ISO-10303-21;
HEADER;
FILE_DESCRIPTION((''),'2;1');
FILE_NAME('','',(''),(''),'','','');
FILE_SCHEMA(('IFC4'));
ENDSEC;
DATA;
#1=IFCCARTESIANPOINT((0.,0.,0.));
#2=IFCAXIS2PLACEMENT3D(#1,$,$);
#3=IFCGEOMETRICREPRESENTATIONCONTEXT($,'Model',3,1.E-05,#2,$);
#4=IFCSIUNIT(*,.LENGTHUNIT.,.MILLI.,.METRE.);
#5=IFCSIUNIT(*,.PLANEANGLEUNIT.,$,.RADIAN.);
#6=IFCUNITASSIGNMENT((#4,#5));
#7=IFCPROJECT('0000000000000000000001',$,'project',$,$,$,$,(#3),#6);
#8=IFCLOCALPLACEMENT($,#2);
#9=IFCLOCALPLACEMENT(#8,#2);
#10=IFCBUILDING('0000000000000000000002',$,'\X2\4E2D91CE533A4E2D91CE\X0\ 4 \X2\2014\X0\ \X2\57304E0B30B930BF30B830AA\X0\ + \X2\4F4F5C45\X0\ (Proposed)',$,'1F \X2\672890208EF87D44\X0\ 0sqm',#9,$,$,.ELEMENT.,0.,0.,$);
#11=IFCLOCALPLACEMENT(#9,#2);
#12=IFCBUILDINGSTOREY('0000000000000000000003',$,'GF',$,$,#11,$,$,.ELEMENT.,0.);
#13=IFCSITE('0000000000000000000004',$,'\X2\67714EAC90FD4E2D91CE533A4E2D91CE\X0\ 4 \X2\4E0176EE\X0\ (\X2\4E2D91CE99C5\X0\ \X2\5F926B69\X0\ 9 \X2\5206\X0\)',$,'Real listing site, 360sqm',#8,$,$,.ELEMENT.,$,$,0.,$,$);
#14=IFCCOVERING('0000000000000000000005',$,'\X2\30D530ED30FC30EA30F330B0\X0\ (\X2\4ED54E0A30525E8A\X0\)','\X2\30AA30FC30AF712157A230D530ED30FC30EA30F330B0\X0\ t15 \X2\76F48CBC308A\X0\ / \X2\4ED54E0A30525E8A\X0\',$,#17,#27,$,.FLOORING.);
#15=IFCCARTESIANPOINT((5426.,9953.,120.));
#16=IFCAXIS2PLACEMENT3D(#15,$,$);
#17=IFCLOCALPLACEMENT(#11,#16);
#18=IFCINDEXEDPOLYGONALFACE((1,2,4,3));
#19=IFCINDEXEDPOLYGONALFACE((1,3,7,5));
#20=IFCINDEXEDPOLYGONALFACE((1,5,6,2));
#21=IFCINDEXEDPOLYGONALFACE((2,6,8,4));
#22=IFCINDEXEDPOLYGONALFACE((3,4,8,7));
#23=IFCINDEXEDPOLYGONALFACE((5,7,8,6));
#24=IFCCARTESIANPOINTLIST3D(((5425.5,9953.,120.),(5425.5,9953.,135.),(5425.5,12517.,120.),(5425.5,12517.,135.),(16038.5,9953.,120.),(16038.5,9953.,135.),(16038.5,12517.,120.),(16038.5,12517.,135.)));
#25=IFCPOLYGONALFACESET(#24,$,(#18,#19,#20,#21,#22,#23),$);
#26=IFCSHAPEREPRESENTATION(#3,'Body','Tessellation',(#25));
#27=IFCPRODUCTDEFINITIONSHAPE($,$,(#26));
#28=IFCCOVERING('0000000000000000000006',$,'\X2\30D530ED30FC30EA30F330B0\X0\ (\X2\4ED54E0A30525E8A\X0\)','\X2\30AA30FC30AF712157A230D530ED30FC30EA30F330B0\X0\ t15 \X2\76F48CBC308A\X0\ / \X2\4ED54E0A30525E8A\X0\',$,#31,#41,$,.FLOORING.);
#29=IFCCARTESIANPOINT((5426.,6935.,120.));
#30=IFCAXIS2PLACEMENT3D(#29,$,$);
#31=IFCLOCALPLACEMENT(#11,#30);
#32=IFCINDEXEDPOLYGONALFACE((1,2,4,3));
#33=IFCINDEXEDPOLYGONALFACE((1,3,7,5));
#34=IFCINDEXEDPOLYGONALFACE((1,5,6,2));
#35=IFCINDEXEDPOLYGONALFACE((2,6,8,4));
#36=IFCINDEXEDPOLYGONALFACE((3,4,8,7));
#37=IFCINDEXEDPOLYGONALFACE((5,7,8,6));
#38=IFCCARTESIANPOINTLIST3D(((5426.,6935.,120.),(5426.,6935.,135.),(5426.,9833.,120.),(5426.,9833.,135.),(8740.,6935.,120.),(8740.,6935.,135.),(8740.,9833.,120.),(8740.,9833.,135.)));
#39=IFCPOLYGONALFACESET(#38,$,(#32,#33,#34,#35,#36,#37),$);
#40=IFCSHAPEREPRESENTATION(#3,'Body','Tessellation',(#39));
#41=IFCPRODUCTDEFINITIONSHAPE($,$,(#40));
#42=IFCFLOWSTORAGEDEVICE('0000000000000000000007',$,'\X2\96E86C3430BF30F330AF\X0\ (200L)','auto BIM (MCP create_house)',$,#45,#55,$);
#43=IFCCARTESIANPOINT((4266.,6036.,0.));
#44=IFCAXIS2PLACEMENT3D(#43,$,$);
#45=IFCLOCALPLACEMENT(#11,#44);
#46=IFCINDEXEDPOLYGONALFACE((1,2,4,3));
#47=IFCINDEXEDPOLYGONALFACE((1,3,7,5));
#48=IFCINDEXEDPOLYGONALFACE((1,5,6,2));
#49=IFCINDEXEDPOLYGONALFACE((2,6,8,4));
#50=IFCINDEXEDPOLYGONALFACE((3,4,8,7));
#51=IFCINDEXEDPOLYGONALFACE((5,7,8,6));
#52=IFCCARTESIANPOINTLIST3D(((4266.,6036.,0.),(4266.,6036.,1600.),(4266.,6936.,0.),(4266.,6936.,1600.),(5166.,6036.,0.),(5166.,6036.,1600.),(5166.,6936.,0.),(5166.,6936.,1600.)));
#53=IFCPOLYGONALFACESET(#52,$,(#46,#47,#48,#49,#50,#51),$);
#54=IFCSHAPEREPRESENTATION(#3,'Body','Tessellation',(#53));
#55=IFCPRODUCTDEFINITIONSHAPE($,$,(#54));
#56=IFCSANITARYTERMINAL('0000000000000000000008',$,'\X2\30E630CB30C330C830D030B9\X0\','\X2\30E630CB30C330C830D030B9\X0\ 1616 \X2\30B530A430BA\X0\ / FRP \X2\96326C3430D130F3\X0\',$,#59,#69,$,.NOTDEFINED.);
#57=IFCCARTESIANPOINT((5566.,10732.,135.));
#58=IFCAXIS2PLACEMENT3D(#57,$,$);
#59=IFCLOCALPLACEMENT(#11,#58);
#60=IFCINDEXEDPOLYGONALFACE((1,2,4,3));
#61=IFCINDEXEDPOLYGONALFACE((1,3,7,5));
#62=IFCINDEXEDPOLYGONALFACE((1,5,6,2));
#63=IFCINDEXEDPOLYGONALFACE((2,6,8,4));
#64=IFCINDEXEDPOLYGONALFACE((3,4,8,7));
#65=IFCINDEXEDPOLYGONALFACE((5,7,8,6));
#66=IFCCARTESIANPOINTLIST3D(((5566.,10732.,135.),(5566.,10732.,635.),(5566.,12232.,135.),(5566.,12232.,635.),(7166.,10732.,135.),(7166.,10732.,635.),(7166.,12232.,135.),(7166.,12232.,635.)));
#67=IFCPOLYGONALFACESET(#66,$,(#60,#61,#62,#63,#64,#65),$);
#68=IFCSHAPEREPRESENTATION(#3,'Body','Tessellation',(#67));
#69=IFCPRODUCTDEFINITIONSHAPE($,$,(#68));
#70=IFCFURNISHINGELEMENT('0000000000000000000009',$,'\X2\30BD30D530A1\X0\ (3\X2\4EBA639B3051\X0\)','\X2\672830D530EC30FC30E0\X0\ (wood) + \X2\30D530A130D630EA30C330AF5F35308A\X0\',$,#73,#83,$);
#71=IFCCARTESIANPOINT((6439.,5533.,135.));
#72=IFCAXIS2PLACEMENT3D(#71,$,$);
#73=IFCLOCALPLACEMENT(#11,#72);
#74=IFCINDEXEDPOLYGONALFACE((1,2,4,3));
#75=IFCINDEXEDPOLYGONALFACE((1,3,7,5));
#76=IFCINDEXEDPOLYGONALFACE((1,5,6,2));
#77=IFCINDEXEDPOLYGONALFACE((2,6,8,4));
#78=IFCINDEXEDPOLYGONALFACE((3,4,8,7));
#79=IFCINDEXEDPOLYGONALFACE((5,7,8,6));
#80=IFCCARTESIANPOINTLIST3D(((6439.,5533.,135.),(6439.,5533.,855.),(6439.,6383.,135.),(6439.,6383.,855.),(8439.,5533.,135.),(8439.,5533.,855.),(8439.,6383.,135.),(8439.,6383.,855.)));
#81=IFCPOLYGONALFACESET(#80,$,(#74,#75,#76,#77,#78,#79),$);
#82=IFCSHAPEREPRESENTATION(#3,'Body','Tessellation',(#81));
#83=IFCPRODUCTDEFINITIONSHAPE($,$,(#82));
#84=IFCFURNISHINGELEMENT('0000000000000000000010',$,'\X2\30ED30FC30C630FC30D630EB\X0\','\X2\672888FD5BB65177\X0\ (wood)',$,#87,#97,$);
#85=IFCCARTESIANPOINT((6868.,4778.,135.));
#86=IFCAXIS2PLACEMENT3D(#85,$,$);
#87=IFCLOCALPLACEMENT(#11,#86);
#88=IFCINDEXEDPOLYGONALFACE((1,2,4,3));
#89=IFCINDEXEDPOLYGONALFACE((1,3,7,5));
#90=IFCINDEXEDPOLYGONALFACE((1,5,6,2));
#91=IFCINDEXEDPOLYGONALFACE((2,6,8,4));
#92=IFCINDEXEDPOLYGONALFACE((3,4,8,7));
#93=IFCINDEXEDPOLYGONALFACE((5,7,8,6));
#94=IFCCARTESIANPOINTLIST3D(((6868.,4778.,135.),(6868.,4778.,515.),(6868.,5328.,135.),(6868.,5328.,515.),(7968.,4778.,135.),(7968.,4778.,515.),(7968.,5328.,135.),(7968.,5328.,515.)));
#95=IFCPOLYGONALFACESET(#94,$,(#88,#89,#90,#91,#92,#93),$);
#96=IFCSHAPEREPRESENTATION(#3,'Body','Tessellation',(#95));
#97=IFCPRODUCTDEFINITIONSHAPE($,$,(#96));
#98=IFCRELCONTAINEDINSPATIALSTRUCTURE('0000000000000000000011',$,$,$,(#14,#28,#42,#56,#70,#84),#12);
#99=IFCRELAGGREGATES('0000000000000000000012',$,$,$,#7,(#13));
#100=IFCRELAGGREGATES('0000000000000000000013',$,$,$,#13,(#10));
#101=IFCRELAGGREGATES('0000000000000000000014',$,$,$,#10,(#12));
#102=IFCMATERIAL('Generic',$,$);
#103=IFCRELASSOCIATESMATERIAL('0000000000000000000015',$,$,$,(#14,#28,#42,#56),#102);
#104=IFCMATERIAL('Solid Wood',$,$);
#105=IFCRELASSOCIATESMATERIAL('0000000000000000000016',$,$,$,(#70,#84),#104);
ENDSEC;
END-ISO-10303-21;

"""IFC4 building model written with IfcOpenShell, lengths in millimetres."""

from ifc_helpers import new_model, si_unit, frame, frame_2d, origin, place, context, project, spatial, rectangle, extrude, material, element, save


model = new_model("IFC4")

# Units and contexts
model_context = context("Model", 3, precision=1e-05, world=origin())
ifc_project = project(units=[si_unit("LENGTHUNIT", "METRE", prefix="MILLI"), si_unit("PLANEANGLEUNIT", "RADIAN")], contexts=[model_context])

# Site, building, storey
site_placement = place(None, origin())
site = spatial("IfcSite", under=ifc_project, at=site_placement, Name="東京都中野区中野 4 丁目 (中野駅 徒歩 9 分)", ObjectType="Real listing site, 360sqm", CompositionType="ELEMENT", RefElevation=0.0)
building_placement = place(site_placement, origin())
building = spatial("IfcBuilding", under=site, at=building_placement, Name="中野区中野 4 — 地下スタジオ + 住居 (Proposed)", ObjectType="1F 木造軸組 0sqm", CompositionType="ELEMENT", ElevationOfRefHeight=0.0, ElevationOfTerrain=0.0)
storey_placement = place(building_placement, origin())
storey = spatial("IfcBuildingStorey", under=building, at=storey_placement, Name="GF", CompositionType="ELEMENT", Elevation=0.0)

# Shared definitions
ifc_material_1 = material(Name="Solid Wood")

# Coverings
ifc_material_2 = material(Name="Generic")
covering_1_placement = place(storey_placement, frame((5426.0, 9953.0, 120.0)))
element("IfcCovering", 1, at=covering_1_placement, inside=storey, material=ifc_material_2, Name="フローリング (仕上げ床)", Description="オーク無垢フローリング t15 直貼り / 仕上げ床", PredefinedType="FLOORING", context=model_context, shape_type="SweptSolid", body=[
    extrude(rectangle(XDim=10613.0, YDim=2564.0, at=frame_2d((5306.0, 1282.0))), frame((5426.0, 9953.0, 120.0)), (0.0, 0.0, 1.0), 15.0),
])
covering_2_placement = place(storey_placement, frame((5426.0, 6935.0, 120.0)))
element("IfcCovering", 2, at=covering_2_placement, inside=storey, material=ifc_material_2, Name="フローリング (仕上げ床)", Description="オーク無垢フローリング t15 直貼り / 仕上げ床", PredefinedType="FLOORING", context=model_context, shape_type="SweptSolid", body=[
    extrude(rectangle(XDim=3314.0, YDim=2898.0, at=frame_2d((1657.0, 1449.0))), frame((5426.0, 6935.0, 120.0)), (0.0, 0.0, 1.0), 15.0),
])

# Flow storage device
flow_storage_device_placement = place(storey_placement, frame((4266.0, 6036.0, 0.0)))
element("IfcFlowStorageDevice", 3, at=flow_storage_device_placement, inside=storey, material=ifc_material_2, Name="雨水タンク (200L)", Description="auto BIM (MCP create_house)", context=model_context, shape_type="SweptSolid", body=[
    extrude(rectangle(XDim=900.0, YDim=900.0, at=frame_2d((450.0, 450.0))), frame((4266.0, 6036.0, 0.0)), (0.0, 0.0, 1.0), 1600.0),
])

# Sanitary terminal
sanitary_terminal_placement = place(storey_placement, frame((5566.0, 10732.0, 135.0)))
element("IfcSanitaryTerminal", 4, at=sanitary_terminal_placement, inside=storey, material=ifc_material_2, Name="ユニットバス", Description="ユニットバス 1616 サイズ / FRP 防水パン", PredefinedType="NOTDEFINED", context=model_context, shape_type="SweptSolid", body=[
    extrude(rectangle(XDim=1600.0, YDim=1500.0, at=frame_2d((800.0, 750.0))), frame((5566.0, 10732.0, 135.0)), (0.0, 0.0, 1.0), 500.0),
])

# Furnishing elements
furnishing_1_placement = place(storey_placement, frame((6439.0, 5533.0, 135.0)))
element("IfcFurnishingElement", 5, at=furnishing_1_placement, inside=storey, material=ifc_material_1, Name="ソファ (3人掛け)", Description="木フレーム (wood) + ファブリック張り", context=model_context, shape_type="SweptSolid", body=[
    extrude(rectangle(XDim=2000.0, YDim=850.0, at=frame_2d((1000.0, 425.0))), frame((6439.0, 5533.0, 135.0)), (0.0, 0.0, 1.0), 720.0),
])
furnishing_2_placement = place(storey_placement, frame((6868.0, 4778.0, 135.0)))
element("IfcFurnishingElement", 6, at=furnishing_2_placement, inside=storey, material=ifc_material_1, Name="ローテーブル", Description="木製家具 (wood)", context=model_context, shape_type="SweptSolid", body=[
    extrude(rectangle(XDim=1100.0, YDim=550.0, at=frame_2d((550.0, 275.0))), frame((6868.0, 4778.0, 135.0)), (0.0, 0.0, 1.0), 380.0),
])

save(model, "model.ifc")
